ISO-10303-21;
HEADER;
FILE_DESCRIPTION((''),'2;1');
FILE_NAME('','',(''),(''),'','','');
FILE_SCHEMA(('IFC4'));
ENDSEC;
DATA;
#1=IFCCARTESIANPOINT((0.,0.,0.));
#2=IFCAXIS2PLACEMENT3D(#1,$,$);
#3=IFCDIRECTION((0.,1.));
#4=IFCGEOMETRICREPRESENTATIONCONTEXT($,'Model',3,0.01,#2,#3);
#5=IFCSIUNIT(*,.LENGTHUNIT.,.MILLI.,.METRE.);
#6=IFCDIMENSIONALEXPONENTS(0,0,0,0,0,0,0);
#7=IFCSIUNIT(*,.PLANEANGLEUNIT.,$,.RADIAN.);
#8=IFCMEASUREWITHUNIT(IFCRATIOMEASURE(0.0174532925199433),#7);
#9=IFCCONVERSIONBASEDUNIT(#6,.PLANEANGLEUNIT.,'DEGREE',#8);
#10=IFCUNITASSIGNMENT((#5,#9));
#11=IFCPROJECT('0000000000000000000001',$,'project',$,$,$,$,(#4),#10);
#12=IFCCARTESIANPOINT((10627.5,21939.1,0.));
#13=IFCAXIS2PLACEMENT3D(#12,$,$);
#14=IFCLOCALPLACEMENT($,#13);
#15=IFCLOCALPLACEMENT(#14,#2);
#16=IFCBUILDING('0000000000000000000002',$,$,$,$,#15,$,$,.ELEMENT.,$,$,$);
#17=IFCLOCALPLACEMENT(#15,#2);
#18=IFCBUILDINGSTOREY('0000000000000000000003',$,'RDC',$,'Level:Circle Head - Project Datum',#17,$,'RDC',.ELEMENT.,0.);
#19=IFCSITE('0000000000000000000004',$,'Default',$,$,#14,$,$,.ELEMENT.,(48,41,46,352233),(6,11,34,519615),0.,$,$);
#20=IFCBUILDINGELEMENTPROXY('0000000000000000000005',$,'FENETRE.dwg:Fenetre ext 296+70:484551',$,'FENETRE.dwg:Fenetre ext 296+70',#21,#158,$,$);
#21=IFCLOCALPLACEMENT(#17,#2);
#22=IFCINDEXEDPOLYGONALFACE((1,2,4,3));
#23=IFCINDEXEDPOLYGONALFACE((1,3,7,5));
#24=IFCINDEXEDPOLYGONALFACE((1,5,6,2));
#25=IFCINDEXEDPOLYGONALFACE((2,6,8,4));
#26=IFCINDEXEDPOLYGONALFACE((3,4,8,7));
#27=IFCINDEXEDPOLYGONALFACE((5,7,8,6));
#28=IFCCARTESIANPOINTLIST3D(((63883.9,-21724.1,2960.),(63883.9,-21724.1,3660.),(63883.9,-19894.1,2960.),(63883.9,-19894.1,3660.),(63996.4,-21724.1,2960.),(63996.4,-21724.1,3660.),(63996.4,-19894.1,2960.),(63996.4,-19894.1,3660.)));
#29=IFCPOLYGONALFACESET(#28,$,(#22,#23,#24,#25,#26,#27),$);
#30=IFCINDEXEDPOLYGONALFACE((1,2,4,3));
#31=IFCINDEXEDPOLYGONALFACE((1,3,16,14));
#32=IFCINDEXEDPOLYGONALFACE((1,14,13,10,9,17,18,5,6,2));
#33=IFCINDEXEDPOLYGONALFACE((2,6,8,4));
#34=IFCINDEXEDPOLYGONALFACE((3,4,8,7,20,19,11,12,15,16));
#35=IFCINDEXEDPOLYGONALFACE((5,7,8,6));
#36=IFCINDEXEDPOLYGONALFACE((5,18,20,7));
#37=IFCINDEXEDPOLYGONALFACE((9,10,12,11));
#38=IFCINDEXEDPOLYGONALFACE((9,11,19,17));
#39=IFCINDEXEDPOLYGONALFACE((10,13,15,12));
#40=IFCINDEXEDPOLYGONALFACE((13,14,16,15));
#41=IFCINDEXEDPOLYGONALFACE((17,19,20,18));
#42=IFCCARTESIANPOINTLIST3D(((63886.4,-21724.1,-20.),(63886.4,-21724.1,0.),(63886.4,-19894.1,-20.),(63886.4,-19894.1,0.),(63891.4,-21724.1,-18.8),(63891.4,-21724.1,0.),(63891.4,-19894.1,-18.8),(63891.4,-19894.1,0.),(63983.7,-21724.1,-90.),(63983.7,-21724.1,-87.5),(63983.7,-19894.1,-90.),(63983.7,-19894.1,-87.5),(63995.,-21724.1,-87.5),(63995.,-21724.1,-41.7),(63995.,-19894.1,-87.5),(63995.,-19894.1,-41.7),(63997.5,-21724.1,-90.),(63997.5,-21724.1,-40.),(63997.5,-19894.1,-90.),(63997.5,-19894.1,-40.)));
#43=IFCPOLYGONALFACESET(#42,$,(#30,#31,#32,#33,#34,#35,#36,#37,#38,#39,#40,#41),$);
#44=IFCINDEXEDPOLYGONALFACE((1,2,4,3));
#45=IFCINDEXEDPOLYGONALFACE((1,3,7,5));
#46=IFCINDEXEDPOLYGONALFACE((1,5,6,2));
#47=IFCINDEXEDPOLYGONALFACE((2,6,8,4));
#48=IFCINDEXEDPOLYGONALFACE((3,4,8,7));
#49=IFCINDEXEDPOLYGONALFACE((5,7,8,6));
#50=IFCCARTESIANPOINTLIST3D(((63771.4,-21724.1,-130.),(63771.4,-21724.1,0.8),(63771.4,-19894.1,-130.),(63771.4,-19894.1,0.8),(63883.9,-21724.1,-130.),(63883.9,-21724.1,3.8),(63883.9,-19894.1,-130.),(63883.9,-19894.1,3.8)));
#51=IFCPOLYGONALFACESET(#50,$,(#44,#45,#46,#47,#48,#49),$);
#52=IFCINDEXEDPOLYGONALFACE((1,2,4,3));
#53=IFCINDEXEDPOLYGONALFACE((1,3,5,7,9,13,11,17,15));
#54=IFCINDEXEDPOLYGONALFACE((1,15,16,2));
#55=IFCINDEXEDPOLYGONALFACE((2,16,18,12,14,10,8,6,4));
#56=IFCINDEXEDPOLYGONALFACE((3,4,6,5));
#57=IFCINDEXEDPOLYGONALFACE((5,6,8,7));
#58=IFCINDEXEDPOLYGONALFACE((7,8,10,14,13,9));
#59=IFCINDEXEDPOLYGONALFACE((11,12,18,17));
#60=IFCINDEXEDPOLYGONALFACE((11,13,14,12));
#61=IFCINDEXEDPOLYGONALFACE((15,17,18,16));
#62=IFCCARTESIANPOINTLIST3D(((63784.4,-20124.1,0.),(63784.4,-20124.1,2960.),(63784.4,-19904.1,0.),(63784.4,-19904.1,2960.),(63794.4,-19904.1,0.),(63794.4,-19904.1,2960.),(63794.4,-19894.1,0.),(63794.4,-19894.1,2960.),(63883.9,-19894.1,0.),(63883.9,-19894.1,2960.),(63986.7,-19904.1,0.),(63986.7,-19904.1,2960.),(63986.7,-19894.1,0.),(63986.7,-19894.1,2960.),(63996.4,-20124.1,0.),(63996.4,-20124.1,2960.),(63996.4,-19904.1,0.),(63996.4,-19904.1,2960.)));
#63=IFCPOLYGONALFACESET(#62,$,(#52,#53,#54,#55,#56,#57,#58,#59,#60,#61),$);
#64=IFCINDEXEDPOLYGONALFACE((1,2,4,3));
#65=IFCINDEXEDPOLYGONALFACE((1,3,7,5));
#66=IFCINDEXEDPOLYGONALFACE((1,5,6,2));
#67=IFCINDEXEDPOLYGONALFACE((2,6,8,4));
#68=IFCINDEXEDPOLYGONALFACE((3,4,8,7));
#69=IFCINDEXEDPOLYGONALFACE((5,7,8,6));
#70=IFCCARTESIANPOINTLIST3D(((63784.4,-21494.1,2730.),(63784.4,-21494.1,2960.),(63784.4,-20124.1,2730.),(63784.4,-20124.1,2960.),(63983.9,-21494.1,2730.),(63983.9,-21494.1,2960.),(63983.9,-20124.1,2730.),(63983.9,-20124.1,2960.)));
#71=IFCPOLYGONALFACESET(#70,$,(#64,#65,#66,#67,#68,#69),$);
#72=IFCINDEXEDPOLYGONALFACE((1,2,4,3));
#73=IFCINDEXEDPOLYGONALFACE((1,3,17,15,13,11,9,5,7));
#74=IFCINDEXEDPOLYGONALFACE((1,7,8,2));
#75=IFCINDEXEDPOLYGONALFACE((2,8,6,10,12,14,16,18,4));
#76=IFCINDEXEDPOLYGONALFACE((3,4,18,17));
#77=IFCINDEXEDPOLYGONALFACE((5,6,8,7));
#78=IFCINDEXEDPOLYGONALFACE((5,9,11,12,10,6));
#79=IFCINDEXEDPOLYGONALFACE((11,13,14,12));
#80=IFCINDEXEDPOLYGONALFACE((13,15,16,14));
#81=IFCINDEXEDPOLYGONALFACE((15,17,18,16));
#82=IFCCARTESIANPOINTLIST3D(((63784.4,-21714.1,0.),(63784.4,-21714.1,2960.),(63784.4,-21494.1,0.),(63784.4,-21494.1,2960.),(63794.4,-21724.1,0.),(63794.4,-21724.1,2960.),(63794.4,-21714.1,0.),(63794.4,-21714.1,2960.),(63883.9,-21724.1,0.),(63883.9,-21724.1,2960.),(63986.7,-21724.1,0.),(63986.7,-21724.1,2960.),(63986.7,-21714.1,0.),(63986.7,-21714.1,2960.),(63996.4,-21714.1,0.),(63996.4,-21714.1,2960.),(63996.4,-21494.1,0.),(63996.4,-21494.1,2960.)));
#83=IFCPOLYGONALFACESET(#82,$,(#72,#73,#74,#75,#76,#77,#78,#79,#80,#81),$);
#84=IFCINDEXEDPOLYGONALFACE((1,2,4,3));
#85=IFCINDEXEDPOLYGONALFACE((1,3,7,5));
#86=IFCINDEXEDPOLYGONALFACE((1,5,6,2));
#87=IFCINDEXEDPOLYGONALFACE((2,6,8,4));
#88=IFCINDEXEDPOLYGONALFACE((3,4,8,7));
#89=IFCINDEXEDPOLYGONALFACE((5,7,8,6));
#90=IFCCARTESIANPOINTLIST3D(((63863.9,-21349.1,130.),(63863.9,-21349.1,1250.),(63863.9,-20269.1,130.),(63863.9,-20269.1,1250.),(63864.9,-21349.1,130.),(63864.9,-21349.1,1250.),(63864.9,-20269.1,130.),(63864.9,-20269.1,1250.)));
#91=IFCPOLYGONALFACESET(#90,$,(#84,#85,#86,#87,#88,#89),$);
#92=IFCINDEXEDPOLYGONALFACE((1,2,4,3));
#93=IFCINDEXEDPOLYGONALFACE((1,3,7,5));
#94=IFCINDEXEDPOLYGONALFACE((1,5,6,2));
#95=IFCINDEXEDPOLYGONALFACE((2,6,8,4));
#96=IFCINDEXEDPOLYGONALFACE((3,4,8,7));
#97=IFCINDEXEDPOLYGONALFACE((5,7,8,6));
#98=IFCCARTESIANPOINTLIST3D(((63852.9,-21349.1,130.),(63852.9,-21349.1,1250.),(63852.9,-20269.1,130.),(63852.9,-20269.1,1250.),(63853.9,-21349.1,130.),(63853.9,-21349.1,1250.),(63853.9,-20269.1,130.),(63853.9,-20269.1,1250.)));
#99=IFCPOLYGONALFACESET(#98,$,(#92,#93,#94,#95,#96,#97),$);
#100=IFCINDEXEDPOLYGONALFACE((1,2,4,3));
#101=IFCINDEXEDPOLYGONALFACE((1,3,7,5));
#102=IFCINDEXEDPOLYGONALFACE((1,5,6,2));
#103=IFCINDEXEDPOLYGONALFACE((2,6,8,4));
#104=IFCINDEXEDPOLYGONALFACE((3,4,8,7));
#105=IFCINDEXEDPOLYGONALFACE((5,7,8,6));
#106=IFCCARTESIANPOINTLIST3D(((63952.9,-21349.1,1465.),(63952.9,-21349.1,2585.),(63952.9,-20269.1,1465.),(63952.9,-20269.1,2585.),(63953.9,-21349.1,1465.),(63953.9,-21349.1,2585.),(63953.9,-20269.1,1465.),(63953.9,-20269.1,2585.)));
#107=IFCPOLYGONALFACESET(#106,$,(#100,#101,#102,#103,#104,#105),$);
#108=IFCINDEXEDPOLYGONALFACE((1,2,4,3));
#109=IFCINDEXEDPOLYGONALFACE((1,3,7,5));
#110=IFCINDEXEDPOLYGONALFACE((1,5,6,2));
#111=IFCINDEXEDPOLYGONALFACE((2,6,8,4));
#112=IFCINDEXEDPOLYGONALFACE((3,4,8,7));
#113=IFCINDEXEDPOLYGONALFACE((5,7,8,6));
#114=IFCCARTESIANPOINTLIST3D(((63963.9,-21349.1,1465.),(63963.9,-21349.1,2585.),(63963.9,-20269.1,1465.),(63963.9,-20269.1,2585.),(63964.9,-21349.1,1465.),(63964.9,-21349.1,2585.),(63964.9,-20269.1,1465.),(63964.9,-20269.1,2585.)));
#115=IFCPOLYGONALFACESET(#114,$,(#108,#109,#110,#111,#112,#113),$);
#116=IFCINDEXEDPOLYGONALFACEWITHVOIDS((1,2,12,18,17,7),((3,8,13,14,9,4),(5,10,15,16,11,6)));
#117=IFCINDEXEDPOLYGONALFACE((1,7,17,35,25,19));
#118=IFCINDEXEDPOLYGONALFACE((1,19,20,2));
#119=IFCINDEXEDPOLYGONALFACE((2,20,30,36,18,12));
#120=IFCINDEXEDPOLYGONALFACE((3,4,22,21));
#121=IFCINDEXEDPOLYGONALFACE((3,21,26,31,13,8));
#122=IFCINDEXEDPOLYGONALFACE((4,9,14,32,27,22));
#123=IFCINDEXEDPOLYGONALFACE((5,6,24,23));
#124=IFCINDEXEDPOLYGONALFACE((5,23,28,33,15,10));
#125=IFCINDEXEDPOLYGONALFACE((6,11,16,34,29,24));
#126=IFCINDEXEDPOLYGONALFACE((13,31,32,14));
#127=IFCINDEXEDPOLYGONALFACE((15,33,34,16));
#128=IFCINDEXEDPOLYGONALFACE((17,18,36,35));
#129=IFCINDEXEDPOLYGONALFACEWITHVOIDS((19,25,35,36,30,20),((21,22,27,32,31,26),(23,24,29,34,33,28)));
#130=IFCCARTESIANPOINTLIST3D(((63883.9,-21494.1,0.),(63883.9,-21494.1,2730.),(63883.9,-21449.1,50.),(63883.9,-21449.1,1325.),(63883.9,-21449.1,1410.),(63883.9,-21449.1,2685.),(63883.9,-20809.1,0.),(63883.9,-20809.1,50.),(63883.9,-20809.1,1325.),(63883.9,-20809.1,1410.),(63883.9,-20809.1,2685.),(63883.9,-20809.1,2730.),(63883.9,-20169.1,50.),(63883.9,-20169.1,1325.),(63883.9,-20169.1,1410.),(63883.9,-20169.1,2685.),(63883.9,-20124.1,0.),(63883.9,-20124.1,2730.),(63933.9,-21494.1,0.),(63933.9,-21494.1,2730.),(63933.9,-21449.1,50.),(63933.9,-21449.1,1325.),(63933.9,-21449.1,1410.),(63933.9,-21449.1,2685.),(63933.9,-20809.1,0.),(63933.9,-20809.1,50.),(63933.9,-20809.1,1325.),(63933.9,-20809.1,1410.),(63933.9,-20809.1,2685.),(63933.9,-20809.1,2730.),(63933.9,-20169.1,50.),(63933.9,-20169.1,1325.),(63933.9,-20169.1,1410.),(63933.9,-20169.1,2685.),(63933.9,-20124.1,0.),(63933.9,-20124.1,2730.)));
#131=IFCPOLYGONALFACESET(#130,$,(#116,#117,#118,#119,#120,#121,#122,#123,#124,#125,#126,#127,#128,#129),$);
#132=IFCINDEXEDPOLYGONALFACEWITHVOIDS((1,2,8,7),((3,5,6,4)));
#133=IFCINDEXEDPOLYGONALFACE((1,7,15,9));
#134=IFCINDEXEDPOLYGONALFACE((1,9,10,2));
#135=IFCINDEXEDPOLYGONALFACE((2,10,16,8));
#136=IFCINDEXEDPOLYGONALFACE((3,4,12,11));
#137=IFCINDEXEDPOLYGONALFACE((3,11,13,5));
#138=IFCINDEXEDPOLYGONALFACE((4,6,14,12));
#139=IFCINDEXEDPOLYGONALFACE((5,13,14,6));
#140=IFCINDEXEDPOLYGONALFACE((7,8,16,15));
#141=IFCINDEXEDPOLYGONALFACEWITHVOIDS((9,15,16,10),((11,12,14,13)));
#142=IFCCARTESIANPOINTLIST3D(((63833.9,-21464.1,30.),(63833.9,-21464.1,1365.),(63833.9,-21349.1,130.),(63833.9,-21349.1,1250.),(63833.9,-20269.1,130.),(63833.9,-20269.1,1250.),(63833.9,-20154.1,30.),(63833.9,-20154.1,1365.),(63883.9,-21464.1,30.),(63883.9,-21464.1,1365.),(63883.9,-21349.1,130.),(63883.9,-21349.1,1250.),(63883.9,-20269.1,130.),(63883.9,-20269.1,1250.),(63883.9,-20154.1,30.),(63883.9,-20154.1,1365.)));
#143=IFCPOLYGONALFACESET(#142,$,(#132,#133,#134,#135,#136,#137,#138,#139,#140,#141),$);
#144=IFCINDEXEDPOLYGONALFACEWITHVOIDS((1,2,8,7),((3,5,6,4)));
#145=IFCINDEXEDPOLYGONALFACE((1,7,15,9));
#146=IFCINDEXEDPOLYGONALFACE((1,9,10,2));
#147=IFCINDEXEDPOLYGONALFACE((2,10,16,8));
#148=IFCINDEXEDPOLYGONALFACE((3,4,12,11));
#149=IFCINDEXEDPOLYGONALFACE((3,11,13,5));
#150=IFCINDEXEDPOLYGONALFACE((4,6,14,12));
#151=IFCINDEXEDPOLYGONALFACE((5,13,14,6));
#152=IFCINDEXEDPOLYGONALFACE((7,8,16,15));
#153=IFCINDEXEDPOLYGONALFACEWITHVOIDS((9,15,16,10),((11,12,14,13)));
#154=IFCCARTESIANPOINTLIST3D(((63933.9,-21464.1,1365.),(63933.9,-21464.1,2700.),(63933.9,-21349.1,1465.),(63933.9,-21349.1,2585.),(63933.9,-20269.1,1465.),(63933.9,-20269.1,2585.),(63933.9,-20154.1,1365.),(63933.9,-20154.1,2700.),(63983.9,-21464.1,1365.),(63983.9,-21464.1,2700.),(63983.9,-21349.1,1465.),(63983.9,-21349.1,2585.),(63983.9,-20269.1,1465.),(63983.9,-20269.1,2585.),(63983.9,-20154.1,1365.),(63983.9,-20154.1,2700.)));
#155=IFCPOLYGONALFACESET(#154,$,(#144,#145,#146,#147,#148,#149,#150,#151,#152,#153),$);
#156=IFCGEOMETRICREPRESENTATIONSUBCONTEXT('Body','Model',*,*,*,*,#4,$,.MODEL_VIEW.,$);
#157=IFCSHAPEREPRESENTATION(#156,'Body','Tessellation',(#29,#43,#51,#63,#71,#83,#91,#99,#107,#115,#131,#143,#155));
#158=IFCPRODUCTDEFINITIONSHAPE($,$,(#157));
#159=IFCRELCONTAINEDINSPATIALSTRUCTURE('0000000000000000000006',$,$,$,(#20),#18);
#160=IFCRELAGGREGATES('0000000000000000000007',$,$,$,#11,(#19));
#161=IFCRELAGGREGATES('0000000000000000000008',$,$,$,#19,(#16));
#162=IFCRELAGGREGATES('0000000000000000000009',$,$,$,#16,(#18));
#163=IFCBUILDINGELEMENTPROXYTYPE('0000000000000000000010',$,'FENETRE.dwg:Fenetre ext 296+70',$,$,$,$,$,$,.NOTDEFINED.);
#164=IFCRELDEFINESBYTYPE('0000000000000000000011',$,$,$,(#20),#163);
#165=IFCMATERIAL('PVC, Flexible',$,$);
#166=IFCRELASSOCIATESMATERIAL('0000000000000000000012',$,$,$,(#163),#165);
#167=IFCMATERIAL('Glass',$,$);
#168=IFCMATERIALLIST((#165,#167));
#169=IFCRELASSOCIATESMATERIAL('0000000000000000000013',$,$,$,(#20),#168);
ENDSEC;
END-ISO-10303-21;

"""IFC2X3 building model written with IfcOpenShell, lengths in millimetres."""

from ifc_helpers import new_model, entity, si_unit, converted_unit, direction, frame, frame_2d, origin, origin_2d_with_axis, place, context, subcontext, project, spatial, polyline, rectangle, outline, extrude, source, transform, mapped, material, material_list, type_object, type_shapes, element, save


model = new_model("IFC2X3")

# Units and contexts
model_context = context("Model", 3, precision=0.01, world=origin(), true_north=direction((0.0, 1.0)))
body_context = subcontext(model_context, "Body", "Model", "MODEL_VIEW")
ifc_project = project(units=[si_unit("LENGTHUNIT", "METRE", prefix="MILLI"), converted_unit("PLANEANGLEUNIT", "DEGREE", entity("IfcRatioMeasure", 0.0174532925199433), si_unit("PLANEANGLEUNIT", "RADIAN"), dimensions=[0, 0, 0, 0, 0, 0, 0])], contexts=[model_context])

# Site, building, storey
site_placement = place(None, frame((10627.5, 21939.1, 0.0)))
site = spatial("IfcSite", under=ifc_project, at=site_placement, Name="Default", CompositionType="ELEMENT", RefLatitude=(48, 41, 46, 352233), RefLongitude=(6, 11, 34, 519615), RefElevation=0.0)
building_placement = place(site_placement, origin())
building = spatial("IfcBuilding", under=site, at=building_placement, CompositionType="ELEMENT")
storey_placement = place(building_placement, origin())
storey = spatial("IfcBuildingStorey", under=building, at=storey_placement, Name="RDC", ObjectType="Level:Circle Head - Project Datum", LongName="RDC", CompositionType="ELEMENT", Elevation=0.0)

# Building element proxy
ifc_material_1 = material(Name="PVC, Flexible")
ifc_material_2 = material(Name="Glass")
building_element_proxy_type_1 = type_object("IfcBuildingElementProxyType", Name="FENETRE.dwg:Fenetre ext 296+70", PredefinedType="NOTDEFINED", material=ifc_material_1)
shared_shape_1 = source(origin(), body_context, "Body", "SweptSolid", [
    extrude(rectangle(XDim=112.5, YDim=1830.0, at=origin_2d_with_axis()), frame((-10.4, -56.3, 2960.0), z_axis=(0.0, 0.0, 1.0), x_axis=(0.0, 1.0, 0.0)), (0.0, 0.0, 1.0), 700.0),
    extrude(outline(polyline([(27.5, -64.4), (47.5, -64.4), (47.5, -59.4), (28.8, -59.4), (7.5, 46.7), (-42.5, 46.7), (-42.5, 32.9), (-40.0, 32.9), (-40.0, 44.2), (5.8, 44.2), (27.5, -64.4)])), frame((-925.4, -66.9, -47.5), z_axis=(1.0, 0.0, 0.0), x_axis=(0.0, 0.0, 1.0)), (0.0, 0.0, 1.0), 1830.0),
    extrude(outline(polyline([(-54.5, -66.1), (58.0, -66.1), (54.5, 67.6), (-58.0, 64.6), (-54.5, -66.1)])), frame((-925.4, 56.3, -63.8), z_axis=(1.0, 0.0, 0.0), x_axis=(0.0, -0.999645, 0.02665)), (0.0, 0.0, 1.0), 1830.0),
    extrude(outline(polyline([(-97.0, -55.6), (5.9, -55.6), (95.4, -55.6), (95.4, -45.6), (105.4, -45.6), (105.4, 174.4), (-106.6, 174.4), (-106.6, -45.6), (-97.0, -45.6), (-97.0, -55.6)])), frame((849.0, -5.9, 0.0), z_axis=(0.0, 0.0, 1.0), x_axis=(0.0, 1.0, 0.0)), (0.0, 0.0, 1.0), 2960.0),
    extrude(rectangle(XDim=1370.0, YDim=199.5, at=origin_2d_with_axis()), frame((-10.4, -0.3, 2730.0), z_axis=(0.0, 0.0, 1.0), x_axis=(-1.0, 0.0, 0.0)), (0.0, 0.0, 1.0), 230.0),
    extrude(outline(polyline([(-55.6, 97.0), (-55.6, -5.9), (-55.6, -95.4), (-45.6, -95.4), (-45.6, -105.4), (174.4, -105.4), (174.4, 106.6), (-45.6, 106.6), (-45.6, 97.0), (-55.6, 97.0)])), frame((-869.9, -5.9, 0.0), z_axis=(0.0, 0.0, -1.0), x_axis=(1.0, 0.0, 0.0)), (0.0, 0.0, -1.0), 2960.0),
    extrude(rectangle(XDim=1080.0, YDim=1.0, at=origin_2d_with_axis()), frame((-10.4, 19.5, 130.0), z_axis=(0.0, 0.0, 1.0), x_axis=(-1.0, 0.0, 0.0)), (0.0, 0.0, 1.0), 1120.0),
    extrude(rectangle(XDim=1080.0, YDim=1.0, at=origin_2d_with_axis()), frame((-10.4, 30.5, 130.0), z_axis=(0.0, 0.0, 1.0), x_axis=(-1.0, 0.0, 0.0)), (0.0, 0.0, 1.0), 1120.0),
    extrude(rectangle(XDim=1080.0, YDim=1.0, at=frame_2d((0.0, 0.0), x_axis=(1.0, 0.0))), frame((-10.4, -69.5, 1465.0), z_axis=(0.0, 0.0, 1.0), x_axis=(-1.0, 0.0, 0.0)), (0.0, 0.0, 1.0), 1120.0),
    extrude(rectangle(XDim=1080.0, YDim=1.0, at=frame_2d((0.0, 0.0), x_axis=(1.0, 0.0))), frame((-10.4, -80.5, 1465.0), z_axis=(0.0, 0.0, 1.0), x_axis=(-1.0, 0.0, 0.0)), (0.0, 0.0, 1.0), 1120.0),
    extrude(outline(polyline([(-685.0, -1365.0), (0.0, -1365.0), (685.0, -1365.0), (685.0, 1365.0), (0.0, 1365.0), (-685.0, 1365.0), (-685.0, -1365.0)]), holes=[polyline([(-640.0, -1320.0), (-640.0, -45.0), (0.0, -45.0), (640.0, -45.0), (640.0, -1320.0), (0.0, -1320.0), (-640.0, -1320.0)]), polyline([(-640.0, 40.0), (-640.0, 1315.0), (0.0, 1315.0), (640.0, 1315.0), (640.0, 40.0), (0.0, 40.0), (-640.0, 40.0)])]), frame((-10.4, -50.0, 1365.0), z_axis=(0.0, 1.0, 0.0), x_axis=(1.0, 0.0, 0.0)), (0.0, 0.0, 1.0), 50.0),
    extrude(outline(polyline([(-655.0, -667.5), (655.0, -667.5), (655.0, 667.5), (-655.0, 667.5), (-655.0, -667.5)]), holes=[polyline([(-540.0, 552.5), (540.0, 552.5), (540.0, -567.5), (-540.0, -567.5), (-540.0, 552.5)])]), frame((-10.4, 0.0, 697.5), z_axis=(0.0, 1.0, 0.0), x_axis=(-1.0, 0.0, 0.0)), (0.0, 0.0, 1.0), 50.0),
    extrude(outline(polyline([(-655.0, -667.5), (655.0, -667.5), (655.0, 667.5), (-655.0, 667.5), (-655.0, -667.5)]), holes=[polyline([(-540.0, 552.5), (540.0, 552.5), (540.0, -567.5), (-540.0, -567.5), (-540.0, 552.5)])]), frame((-10.4, -100.0, 2032.5), z_axis=(0.0, 1.0, 0.0), x_axis=(-1.0, 0.0, 0.0)), (0.0, 0.0, 1.0), 50.0),
])
type_shapes(building_element_proxy_type_1, [shared_shape_1])
ifc_material_list_1 = material_list([ifc_material_1, ifc_material_2])
proxy_1_placement = place(storey_placement, frame((63883.9, -20798.7, 0.0), z_axis=(0.0, 0.0, 1.0), x_axis=(0.0, 1.0, 0.0)))
element("IfcBuildingElementProxy", 1, at=proxy_1_placement, inside=storey, type_object=building_element_proxy_type_1, material=ifc_material_list_1, Name="FENETRE.dwg:Fenetre ext 296+70:484551", ObjectType="FENETRE.dwg:Fenetre ext 296+70", context=body_context, shape_type="MappedRepresentation", body=[
    mapped(shared_shape_1, transform((0.0, 0.0, 0.0), scale=1.0)),
])

save(model, "model.ifc")
